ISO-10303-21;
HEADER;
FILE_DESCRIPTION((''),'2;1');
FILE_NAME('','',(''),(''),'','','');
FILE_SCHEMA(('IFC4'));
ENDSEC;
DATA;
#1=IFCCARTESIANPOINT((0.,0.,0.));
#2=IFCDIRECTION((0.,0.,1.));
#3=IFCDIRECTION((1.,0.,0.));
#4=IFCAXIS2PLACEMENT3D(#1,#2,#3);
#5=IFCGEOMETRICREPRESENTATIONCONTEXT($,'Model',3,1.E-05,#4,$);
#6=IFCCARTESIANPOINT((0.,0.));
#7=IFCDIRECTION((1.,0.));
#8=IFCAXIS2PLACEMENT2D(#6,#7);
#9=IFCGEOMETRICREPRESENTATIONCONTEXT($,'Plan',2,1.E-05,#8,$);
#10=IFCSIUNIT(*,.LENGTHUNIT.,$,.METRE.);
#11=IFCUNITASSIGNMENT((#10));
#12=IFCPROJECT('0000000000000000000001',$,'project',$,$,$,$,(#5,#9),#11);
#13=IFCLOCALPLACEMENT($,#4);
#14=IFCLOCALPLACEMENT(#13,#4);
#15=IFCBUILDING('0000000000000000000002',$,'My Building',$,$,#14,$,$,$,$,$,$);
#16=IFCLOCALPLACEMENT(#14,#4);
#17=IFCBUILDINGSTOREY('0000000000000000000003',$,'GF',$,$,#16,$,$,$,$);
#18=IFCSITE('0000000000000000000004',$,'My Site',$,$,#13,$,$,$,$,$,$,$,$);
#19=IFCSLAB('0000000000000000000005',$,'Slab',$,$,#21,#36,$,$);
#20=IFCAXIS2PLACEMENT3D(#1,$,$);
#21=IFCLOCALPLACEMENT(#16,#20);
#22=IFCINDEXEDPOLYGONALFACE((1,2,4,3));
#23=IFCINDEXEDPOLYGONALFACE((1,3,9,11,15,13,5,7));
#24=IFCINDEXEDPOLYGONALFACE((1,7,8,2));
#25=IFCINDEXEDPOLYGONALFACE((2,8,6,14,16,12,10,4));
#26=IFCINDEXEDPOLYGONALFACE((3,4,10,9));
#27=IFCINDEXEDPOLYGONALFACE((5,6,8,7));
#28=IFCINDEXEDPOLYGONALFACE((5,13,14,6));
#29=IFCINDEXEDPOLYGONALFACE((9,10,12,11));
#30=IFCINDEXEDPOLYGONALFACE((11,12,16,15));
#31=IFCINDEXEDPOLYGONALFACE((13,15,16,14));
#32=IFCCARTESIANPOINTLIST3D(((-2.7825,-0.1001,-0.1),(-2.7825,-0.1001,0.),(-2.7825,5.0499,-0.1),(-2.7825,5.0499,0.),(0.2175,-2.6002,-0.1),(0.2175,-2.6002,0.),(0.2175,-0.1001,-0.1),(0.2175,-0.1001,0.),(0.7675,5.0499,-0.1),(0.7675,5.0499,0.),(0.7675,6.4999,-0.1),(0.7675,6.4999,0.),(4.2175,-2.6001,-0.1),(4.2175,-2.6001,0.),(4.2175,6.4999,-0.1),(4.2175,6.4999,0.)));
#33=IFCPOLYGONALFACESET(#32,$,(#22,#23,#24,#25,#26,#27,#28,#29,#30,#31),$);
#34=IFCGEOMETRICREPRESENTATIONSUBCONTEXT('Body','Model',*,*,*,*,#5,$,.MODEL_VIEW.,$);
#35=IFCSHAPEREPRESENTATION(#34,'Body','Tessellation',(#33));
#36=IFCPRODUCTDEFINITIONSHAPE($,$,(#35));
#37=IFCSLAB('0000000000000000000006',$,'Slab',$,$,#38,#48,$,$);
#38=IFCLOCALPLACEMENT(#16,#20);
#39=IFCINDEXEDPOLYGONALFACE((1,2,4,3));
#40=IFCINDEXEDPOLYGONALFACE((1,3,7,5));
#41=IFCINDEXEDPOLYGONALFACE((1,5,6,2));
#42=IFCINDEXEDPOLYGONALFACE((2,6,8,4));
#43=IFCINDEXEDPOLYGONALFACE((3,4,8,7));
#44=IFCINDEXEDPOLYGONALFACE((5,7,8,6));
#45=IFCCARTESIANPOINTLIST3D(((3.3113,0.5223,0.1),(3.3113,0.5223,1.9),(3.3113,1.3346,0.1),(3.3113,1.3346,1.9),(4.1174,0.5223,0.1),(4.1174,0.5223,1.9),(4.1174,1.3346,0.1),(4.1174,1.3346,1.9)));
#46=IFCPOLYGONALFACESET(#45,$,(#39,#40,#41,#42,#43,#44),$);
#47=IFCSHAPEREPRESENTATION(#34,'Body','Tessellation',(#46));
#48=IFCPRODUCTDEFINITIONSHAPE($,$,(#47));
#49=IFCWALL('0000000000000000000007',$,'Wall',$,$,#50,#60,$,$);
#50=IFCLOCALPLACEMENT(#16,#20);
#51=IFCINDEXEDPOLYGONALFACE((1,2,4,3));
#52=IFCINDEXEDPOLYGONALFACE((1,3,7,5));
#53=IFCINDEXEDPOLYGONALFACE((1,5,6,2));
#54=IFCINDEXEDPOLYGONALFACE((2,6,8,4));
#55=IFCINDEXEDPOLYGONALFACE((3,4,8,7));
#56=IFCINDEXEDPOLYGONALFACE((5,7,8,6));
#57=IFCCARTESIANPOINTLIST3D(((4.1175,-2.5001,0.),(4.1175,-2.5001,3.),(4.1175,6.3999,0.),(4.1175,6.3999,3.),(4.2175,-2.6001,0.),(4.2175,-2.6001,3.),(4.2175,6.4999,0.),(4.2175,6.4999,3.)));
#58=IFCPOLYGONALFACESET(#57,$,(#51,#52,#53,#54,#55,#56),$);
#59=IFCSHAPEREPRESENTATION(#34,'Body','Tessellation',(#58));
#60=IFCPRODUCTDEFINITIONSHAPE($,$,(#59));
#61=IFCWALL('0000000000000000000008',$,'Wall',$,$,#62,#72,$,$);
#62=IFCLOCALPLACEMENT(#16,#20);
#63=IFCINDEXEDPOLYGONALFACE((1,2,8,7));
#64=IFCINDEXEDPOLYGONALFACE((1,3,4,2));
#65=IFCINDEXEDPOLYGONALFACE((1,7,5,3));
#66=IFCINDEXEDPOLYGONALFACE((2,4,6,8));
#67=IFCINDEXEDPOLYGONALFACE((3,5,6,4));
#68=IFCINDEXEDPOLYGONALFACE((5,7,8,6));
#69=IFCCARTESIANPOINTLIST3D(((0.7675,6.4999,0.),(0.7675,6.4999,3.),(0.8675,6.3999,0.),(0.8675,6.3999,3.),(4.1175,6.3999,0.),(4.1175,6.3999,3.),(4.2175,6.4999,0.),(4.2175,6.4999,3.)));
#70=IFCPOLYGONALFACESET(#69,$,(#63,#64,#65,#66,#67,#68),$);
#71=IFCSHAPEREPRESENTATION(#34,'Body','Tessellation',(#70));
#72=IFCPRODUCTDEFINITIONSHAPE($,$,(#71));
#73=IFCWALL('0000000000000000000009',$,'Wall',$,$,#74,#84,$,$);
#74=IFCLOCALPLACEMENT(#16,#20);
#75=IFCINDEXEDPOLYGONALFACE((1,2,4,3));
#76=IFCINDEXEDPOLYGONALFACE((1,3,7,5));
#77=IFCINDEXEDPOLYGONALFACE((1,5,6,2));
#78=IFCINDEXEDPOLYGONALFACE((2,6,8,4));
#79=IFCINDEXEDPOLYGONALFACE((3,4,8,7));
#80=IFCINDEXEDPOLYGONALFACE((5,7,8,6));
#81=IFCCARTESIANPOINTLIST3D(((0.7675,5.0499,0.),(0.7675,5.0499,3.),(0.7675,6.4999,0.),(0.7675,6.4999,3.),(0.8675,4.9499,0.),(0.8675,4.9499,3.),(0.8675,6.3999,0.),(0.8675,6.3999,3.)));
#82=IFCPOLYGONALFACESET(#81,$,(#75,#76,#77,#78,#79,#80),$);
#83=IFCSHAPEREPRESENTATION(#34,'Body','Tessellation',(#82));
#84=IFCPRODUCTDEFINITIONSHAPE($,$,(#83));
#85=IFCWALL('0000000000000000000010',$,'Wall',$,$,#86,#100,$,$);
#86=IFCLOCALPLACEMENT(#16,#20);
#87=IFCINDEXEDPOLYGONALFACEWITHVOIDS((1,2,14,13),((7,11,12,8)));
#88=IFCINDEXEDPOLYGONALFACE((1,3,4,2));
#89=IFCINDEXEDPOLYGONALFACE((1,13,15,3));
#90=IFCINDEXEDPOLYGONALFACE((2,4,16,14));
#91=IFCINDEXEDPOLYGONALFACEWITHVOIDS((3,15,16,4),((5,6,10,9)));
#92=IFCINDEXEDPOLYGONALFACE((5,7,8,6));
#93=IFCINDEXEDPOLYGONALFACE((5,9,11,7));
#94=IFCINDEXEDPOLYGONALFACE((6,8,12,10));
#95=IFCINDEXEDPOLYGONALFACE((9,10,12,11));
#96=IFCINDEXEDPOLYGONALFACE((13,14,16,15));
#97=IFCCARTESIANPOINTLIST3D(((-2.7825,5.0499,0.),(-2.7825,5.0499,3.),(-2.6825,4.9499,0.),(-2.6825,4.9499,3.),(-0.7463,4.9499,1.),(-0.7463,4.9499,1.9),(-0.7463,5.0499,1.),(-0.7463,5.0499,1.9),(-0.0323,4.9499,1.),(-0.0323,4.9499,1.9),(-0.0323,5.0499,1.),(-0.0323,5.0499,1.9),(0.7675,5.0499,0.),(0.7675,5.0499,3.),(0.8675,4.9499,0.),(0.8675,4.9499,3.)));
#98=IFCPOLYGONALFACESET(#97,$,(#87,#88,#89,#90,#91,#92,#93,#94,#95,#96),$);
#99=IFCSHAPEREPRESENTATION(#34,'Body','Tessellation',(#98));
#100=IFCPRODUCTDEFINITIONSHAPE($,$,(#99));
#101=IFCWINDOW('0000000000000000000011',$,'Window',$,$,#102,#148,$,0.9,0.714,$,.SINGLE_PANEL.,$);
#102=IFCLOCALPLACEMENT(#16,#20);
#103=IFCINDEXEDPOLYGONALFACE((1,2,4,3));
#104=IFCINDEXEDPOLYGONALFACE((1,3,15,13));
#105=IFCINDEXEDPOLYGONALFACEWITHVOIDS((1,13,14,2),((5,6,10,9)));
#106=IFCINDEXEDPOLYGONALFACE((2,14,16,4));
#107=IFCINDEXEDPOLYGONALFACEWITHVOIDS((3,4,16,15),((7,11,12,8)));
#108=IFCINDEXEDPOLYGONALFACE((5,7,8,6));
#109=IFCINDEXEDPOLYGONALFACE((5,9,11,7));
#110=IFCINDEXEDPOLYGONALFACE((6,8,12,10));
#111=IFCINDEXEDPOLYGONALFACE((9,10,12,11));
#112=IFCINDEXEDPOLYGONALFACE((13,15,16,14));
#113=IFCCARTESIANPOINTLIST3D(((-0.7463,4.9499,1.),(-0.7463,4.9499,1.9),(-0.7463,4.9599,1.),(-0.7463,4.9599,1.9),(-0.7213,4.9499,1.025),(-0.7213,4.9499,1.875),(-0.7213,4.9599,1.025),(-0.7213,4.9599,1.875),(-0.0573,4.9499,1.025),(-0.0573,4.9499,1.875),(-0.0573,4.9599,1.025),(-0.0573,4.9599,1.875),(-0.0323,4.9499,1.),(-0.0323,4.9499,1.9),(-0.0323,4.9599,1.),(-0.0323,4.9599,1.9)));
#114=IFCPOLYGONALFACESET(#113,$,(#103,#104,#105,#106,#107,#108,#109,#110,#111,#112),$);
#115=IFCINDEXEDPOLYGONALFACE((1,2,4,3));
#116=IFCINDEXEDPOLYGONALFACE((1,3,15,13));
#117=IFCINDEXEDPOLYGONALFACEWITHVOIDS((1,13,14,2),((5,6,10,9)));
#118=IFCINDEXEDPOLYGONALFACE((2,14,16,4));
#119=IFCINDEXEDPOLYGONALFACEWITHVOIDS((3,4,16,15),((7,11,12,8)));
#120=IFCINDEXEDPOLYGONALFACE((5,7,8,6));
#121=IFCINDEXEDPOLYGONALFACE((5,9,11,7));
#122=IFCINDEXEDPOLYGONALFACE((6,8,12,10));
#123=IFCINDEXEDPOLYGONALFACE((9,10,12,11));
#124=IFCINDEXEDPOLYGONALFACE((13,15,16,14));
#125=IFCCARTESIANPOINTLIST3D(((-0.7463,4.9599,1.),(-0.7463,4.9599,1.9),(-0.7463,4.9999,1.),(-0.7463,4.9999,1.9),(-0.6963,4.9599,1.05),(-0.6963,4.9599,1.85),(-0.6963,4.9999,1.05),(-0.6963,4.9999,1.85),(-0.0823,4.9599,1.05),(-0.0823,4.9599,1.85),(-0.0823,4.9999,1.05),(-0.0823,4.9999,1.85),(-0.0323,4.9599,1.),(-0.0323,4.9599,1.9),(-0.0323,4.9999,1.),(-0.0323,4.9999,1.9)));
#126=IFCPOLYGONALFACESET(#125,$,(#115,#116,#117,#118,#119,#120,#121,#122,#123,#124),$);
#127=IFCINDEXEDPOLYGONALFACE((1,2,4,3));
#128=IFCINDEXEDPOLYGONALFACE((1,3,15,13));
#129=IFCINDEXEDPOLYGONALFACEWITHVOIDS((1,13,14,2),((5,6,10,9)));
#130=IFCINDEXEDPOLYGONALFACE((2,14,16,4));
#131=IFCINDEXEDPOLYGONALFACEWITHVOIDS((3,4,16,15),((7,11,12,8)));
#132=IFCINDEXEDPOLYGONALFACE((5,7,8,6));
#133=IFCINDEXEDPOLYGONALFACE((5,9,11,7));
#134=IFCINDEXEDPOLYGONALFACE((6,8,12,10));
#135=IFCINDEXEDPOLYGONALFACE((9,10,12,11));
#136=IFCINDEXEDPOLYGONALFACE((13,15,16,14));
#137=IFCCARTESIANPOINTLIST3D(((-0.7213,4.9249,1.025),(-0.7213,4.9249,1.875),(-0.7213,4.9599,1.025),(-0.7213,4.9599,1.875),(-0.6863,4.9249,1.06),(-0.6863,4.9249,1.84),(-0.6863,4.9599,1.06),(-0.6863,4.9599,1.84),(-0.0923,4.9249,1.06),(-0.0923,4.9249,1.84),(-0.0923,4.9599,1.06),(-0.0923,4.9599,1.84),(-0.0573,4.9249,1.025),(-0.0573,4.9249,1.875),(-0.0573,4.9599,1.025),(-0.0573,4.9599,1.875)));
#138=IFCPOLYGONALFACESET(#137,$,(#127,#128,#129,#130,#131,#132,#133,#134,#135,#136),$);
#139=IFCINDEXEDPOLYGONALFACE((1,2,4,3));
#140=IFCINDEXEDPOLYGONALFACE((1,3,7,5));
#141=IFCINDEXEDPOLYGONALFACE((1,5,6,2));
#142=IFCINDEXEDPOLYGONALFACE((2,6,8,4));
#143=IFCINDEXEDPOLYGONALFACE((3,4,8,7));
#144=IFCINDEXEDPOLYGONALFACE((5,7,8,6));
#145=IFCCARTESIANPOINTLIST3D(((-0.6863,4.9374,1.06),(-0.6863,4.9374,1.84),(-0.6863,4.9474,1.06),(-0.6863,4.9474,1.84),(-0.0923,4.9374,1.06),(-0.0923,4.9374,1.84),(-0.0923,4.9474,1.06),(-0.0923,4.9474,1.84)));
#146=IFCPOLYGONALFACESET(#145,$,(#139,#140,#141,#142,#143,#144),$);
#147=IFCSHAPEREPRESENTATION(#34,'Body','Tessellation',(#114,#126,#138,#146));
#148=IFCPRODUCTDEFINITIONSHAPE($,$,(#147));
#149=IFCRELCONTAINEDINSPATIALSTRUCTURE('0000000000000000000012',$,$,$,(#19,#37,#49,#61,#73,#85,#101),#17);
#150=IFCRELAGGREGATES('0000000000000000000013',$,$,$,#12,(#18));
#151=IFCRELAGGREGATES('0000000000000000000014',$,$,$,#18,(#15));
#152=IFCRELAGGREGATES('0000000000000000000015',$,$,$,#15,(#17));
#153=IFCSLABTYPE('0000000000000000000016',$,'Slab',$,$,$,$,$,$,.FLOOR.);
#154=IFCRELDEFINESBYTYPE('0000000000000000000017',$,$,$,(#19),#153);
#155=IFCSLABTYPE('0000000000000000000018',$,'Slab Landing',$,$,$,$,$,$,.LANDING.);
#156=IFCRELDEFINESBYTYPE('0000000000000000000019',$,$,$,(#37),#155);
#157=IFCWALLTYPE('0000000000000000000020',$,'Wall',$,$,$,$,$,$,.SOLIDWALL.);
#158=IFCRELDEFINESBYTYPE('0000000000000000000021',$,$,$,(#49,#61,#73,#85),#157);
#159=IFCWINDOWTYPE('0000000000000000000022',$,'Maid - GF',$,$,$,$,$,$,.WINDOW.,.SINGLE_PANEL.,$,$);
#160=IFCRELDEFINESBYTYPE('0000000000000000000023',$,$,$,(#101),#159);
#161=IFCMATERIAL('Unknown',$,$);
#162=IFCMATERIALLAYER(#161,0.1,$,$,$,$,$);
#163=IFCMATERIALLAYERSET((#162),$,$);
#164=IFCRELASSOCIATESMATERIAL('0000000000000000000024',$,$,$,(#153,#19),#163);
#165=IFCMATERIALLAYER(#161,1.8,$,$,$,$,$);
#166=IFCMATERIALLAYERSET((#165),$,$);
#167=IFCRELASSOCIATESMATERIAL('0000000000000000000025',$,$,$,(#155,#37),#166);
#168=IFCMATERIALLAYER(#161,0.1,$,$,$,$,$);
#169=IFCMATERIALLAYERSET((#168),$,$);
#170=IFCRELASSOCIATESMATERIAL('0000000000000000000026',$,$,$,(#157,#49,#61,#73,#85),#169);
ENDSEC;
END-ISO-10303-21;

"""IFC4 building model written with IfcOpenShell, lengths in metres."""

from ifc_helpers import new_model, entity, si_unit, frame, origin_with_axes, origin_2d_with_axis, place, context, subcontext, project, spatial, line, indexed_curve, outline, extrude, shape, source, transform, mapped, material, layer, layer_set, layer_usage, type_object, type_shapes, element, fill, save


model = new_model("IFC4")

# Units and contexts
model_context = context("Model", 3, precision=1e-05, world=origin_with_axes())
plan_context = context("Plan", 2, precision=1e-05, world=origin_2d_with_axis())
body_context_1 = subcontext(model_context, "Body", "Model", "MODEL_VIEW")
body_context_2 = subcontext(plan_context, "Body", "Plan", "PLAN_VIEW")
ifc_project = project(units=[si_unit("LENGTHUNIT", "METRE")], contexts=[model_context, plan_context])

# Site, building, storey
site_placement = place(None, origin_with_axes())
site = spatial("IfcSite", under=ifc_project, at=site_placement, Name="My Site")
building_placement = place(site_placement, origin_with_axes())
building = spatial("IfcBuilding", under=site, at=building_placement, Name="My Building")
storey_placement = place(building_placement, origin_with_axes())
storey = spatial("IfcBuildingStorey", under=building, at=storey_placement, Name="GF")

# Slabs
ifc_material_1 = material(Name="Unknown")
ifc_layer_1 = layer(ifc_material_1, 0.1)
ifc_layer_set_1 = layer_set([ifc_layer_1])
ifc_layer_usage_1 = layer_usage(ifc_layer_set_1, "AXIS3", "POSITIVE", -0.1)
slab_type_1 = type_object("IfcSlabType", Name="Slab", PredefinedType="FLOOR", material=ifc_layer_set_1)
slab_1_placement = place(storey_placement, frame((4.2175, -2.6001, 0.0), z_axis=(0.0, 0.0, 1.0), x_axis=(1.0, 0.0, 0.0)))
element("IfcSlab", 1, at=slab_1_placement, inside=storey, type_object=slab_type_1, material=ifc_layer_usage_1, Name="Slab", context=body_context_1, shape_type="SweptSolid", body=[
    extrude(outline(indexed_curve([(0.0, 0.0), (0.0, 9.1), (-3.45, 9.1), (-3.45, 7.6499), (-7.0, 7.6499), (-7.0, 2.5), (-4.0, 2.5), (-4.0, -0.0001), (0.0, 0.0)])), frame((0.0, 0.0, -0.1), z_axis=(0.0, 0.0, 1.0), x_axis=(1.0, 0.0, 0.0)), (0.0, 0.0, 1.0), 0.1),
])
ifc_layer_2 = layer(ifc_material_1, 1.8)
ifc_layer_set_2 = layer_set([ifc_layer_2])
ifc_layer_usage_2 = layer_usage(ifc_layer_set_2, "AXIS3", "POSITIVE", -0.1)
slab_type_2 = type_object("IfcSlabType", Name="Slab Landing", PredefinedType="LANDING", material=ifc_layer_set_2)
slab_2_placement = place(storey_placement, frame((3.3113, 1.3346, 0.2), z_axis=(0.0, 0.0, 1.0), x_axis=(1.0, 0.0, 0.0)))
element("IfcSlab", 2, at=slab_2_placement, inside=storey, type_object=slab_type_2, material=ifc_layer_usage_2, Name="Slab", context=body_context_1, shape_type="SweptSolid", body=[
    extrude(outline(indexed_curve([(0.0, 0.0), (0.0, -0.8123), (0.8061, -0.8123), (0.8061, 0.0), (0.0, 0.0)])), frame((0.0, 0.0, -0.1), z_axis=(0.0, 0.0, 1.0), x_axis=(1.0, 0.0, 0.0)), (0.0, 0.0, 1.0), 1.8),
])

# Shared definitions
ifc_layer_3 = layer(ifc_material_1, 0.1)
ifc_layer_set_3 = layer_set([ifc_layer_3])
wall_type = type_object("IfcWallType", Name="Wall", PredefinedType="SOLIDWALL", material=ifc_layer_set_3)

# Walls
ifc_layer_usage_3 = layer_usage(ifc_layer_set_3, "AXIS2", "POSITIVE", 0.0)
wall_1_placement = place(storey_placement, frame((4.2175, -2.6001, 0.0), z_axis=(0.0, 0.0, 1.0), x_axis=(0.0, 1.0, 0.0)))
element("IfcWall", 3, at=wall_1_placement, inside=storey, type_object=wall_type, material=ifc_layer_usage_3, Name="Wall", context=body_context_1, shape_type="SweptSolid", body=[
    extrude(outline(indexed_curve([(0.0, 0.0), (0.1, 0.1), (9.0, 0.1), (9.1, 0.0)], segments=[line(1, 2, 3, 4, 1)])), origin_with_axes(), (0.0, 0.0, 1.0), 3.0),
])
ifc_layer_usage_4 = layer_usage(ifc_layer_set_3, "AXIS2", "POSITIVE", 0.0)
wall_2_placement = place(storey_placement, frame((4.2175, 6.4999, 0.0), z_axis=(0.0, 0.0, 1.0), x_axis=(-1.0, 0.0, 0.0)))
element("IfcWall", 4, at=wall_2_placement, inside=storey, type_object=wall_type, material=ifc_layer_usage_4, Name="Wall", context=body_context_1, shape_type="SweptSolid", body=[
    extrude(outline(indexed_curve([(0.0, 0.0), (0.1, 0.1), (3.35, 0.1), (3.45, 0.0)], segments=[line(1, 2, 3, 4, 1)])), origin_with_axes(), (0.0, 0.0, 1.0), 3.0),
])
ifc_layer_usage_5 = layer_usage(ifc_layer_set_3, "AXIS2", "POSITIVE", 0.0)
wall_3_placement = place(storey_placement, frame((0.7675, 6.4999, 0.0), z_axis=(0.0, 0.0, 1.0), x_axis=(0.0, -1.0, 0.0)))
element("IfcWall", 5, at=wall_3_placement, inside=storey, type_object=wall_type, material=ifc_layer_usage_5, Name="Wall", context=body_context_1, shape_type="SweptSolid", body=[
    extrude(outline(indexed_curve([(0.0, 0.0), (0.1, 0.1), (1.55, 0.1), (1.45, 0.0)], segments=[line(1, 2, 3, 4, 1)])), origin_with_axes(), (0.0, 0.0, 1.0), 3.0),
])

# Wall, opening, window
ifc_layer_usage_6 = layer_usage(ifc_layer_set_3, "AXIS2", "POSITIVE", 0.0)
wall_4_placement = place(storey_placement, frame((0.7675, 5.0499, 0.0), z_axis=(0.0, 0.0, 1.0), x_axis=(-1.0, 0.0, 0.0)))
wall_4 = element("IfcWall", 6, at=wall_4_placement, inside=storey, type_object=wall_type, material=ifc_layer_usage_6, Name="Wall", context=body_context_1, shape_type="SweptSolid", body=[
    extrude(outline(indexed_curve([(0.0, 0.0), (-0.1, 0.1), (3.45, 0.1), (3.55, 0.0)], segments=[line(1, 2, 3, 4, 1)])), origin_with_axes(), (0.0, 0.0, 1.0), 3.0),
])
shared_shape_1 = source(origin_with_axes(), body_context_1, "Body", "SweptSolid", [
    extrude(outline(indexed_curve([(0.0, 0.0), (0.714, 0.0), (0.714, 0.9), (0.0, 0.9)], segments=[line(1, 2, 3, 4, 1)])), frame((0.0, -0.6, 0.0), z_axis=(0.0, -1.0, 0.0), x_axis=(1.0, 0.0, 0.0)), (0.0, 0.0, -1.0), 1.2),
])
opening_1_placement = place(wall_4_placement, frame((0.7998, 0.0, 1.0), z_axis=(0.0, 0.0, 1.0), x_axis=(1.0, 0.0, 0.0)))
opening_1 = element("IfcOpeningElement", 7, at=opening_1_placement, cuts=wall_4, PredefinedType="OPENING", context=body_context_1, shape_type="MappedRepresentation", body=[
    mapped(shared_shape_1, transform((0.0, 0.0, 0.0), x_axis=(1.0, 0.0, 0.0), y_axis=(0.0, 1.0, 0.0), z_axis=(0.0, 0.0, 1.0), scale=1.0)),
])
window_type_1 = type_object("IfcWindowType", Name="Maid - GF", PartitioningType="SINGLE_PANEL", PredefinedType="WINDOW")
shared_shape_2 = source(origin_with_axes(), body_context_1, "Body", "SweptSolid", [
    extrude(outline(indexed_curve([(0.0, 0.0), (0.714, 0.0), (0.714, 0.9), (0.0, 0.9)], segments=[line(1, 2, 3, 4, 1)]), holes=[indexed_curve([(0.025, 0.025), (0.689, 0.025), (0.689, 0.875), (0.025, 0.875)], segments=[line(1, 2, 3, 4, 1)])]), frame((0.0, 0.09, 0.0), z_axis=(0.0, -1.0, 0.0), x_axis=(1.0, 0.0, 0.0)), (0.0, 0.0, -1.0), 0.01),
    extrude(outline(indexed_curve([(0.0, 0.0), (0.714, 0.0), (0.714, 0.9), (0.0, 0.9)], segments=[line(1, 2, 3, 4, 1)]), holes=[indexed_curve([(0.05, 0.05), (0.664, 0.05), (0.664, 0.85), (0.05, 0.85)], segments=[line(1, 2, 3, 4, 1)])]), frame((0.0, 0.05, 0.0), z_axis=(0.0, -1.0, 0.0), x_axis=(1.0, 0.0, 0.0)), (0.0, 0.0, -1.0), 0.04),
    extrude(outline(indexed_curve([(0.0, 0.0), (0.664, 0.0), (0.664, 0.85), (0.0, 0.85)], segments=[line(1, 2, 3, 4, 1)]), holes=[indexed_curve([(0.035, 0.035), (0.629, 0.035), (0.629, 0.815), (0.035, 0.815)], segments=[line(1, 2, 3, 4, 1)])]), frame((0.025, 0.09, 0.025), z_axis=(0.0, -1.0, 0.0), x_axis=(1.0, 0.0, 0.0)), (0.0, 0.0, -1.0), 0.035),
    extrude(outline(indexed_curve([(0.035, 0.035), (0.629, 0.035), (0.629, 0.815), (0.035, 0.815)], segments=[line(1, 2, 3, 4, 1)])), frame((0.025, 0.1025, 0.025), z_axis=(0.0, -1.0, 0.0), x_axis=(1.0, 0.0, 0.0)), (0.0, 0.0, -1.0), 0.01),
])
shared_shape_3 = source(origin_with_axes(), body_context_2, "Body", "Curve2D", [
    entity("IfcIndexedPolyCurve", entity("IfcCartesianPointList2D", [[0.05, 0.05], [0.664, 0.05]])),
    entity("IfcIndexedPolyCurve", entity("IfcCartesianPointList2D", [[0.0, 0.1], [0.025, 0.1], [0.025, 0.09], [0.05, 0.09], [0.05, 0.05], [0.0, 0.05]]), [entity("IfcLineIndex", [1, 2, 3, 4, 5, 6, 1])]),
    entity("IfcIndexedPolyCurve", entity("IfcCartesianPointList2D", [[0.714, 0.1], [0.689, 0.1], [0.689, 0.09], [0.664, 0.09], [0.664, 0.05], [0.714, 0.05]]), [entity("IfcLineIndex", [1, 2, 3, 4, 5, 6, 1])]),
    entity("IfcIndexedPolyCurve", entity("IfcCartesianPointList2D", [[0.025, 0.09], [0.06, 0.09], [0.06, 0.125], [0.025, 0.125]]), [entity("IfcLineIndex", [1, 2, 3, 4, 1])]),
    entity("IfcIndexedPolyCurve", entity("IfcCartesianPointList2D", [[0.689, 0.09], [0.654, 0.09], [0.654, 0.125], [0.689, 0.125]]), [entity("IfcLineIndex", [1, 2, 3, 4, 1])]),
    entity("IfcIndexedPolyCurve", entity("IfcCartesianPointList2D", [[0.06, 0.09], [0.654, 0.09]])),
    entity("IfcIndexedPolyCurve", entity("IfcCartesianPointList2D", [[0.06, 0.125], [0.654, 0.125]])),
    entity("IfcIndexedPolyCurve", entity("IfcCartesianPointList2D", [[0.06, 0.1075], [0.654, 0.1075]])),
])
type_shapes(window_type_1, [shared_shape_2, shared_shape_3])
window_1_placement = place(opening_1_placement, frame((0.0, 0.0, 0.0), z_axis=(0.0, 0.0, 1.0), x_axis=(1.0, 0.0, 0.0)))
window_1 = element("IfcWindow", 8, at=window_1_placement, inside=storey, type_object=window_type_1, Name="Window", OverallHeight=0.9, OverallWidth=0.714, PartitioningType="SINGLE_PANEL", shapes=[
    shape(body_context_1, "Body", "MappedRepresentation", [mapped(shared_shape_2, transform((0.0, 0.0, 0.0), x_axis=(1.0, 0.0, 0.0), y_axis=(0.0, 1.0, 0.0), z_axis=(0.0, 0.0, 1.0), scale=1.0))]),
    shape(body_context_2, "Body", "MappedRepresentation", [mapped(shared_shape_3, transform((0.0, 0.0, 0.0), x_axis=(1.0, 0.0, 0.0), y_axis=(0.0, 1.0, 0.0), z_axis=(0.0, 0.0, 1.0), scale=1.0))]),
])
fill(opening_1, window_1)

save(model, "model.ifc")
